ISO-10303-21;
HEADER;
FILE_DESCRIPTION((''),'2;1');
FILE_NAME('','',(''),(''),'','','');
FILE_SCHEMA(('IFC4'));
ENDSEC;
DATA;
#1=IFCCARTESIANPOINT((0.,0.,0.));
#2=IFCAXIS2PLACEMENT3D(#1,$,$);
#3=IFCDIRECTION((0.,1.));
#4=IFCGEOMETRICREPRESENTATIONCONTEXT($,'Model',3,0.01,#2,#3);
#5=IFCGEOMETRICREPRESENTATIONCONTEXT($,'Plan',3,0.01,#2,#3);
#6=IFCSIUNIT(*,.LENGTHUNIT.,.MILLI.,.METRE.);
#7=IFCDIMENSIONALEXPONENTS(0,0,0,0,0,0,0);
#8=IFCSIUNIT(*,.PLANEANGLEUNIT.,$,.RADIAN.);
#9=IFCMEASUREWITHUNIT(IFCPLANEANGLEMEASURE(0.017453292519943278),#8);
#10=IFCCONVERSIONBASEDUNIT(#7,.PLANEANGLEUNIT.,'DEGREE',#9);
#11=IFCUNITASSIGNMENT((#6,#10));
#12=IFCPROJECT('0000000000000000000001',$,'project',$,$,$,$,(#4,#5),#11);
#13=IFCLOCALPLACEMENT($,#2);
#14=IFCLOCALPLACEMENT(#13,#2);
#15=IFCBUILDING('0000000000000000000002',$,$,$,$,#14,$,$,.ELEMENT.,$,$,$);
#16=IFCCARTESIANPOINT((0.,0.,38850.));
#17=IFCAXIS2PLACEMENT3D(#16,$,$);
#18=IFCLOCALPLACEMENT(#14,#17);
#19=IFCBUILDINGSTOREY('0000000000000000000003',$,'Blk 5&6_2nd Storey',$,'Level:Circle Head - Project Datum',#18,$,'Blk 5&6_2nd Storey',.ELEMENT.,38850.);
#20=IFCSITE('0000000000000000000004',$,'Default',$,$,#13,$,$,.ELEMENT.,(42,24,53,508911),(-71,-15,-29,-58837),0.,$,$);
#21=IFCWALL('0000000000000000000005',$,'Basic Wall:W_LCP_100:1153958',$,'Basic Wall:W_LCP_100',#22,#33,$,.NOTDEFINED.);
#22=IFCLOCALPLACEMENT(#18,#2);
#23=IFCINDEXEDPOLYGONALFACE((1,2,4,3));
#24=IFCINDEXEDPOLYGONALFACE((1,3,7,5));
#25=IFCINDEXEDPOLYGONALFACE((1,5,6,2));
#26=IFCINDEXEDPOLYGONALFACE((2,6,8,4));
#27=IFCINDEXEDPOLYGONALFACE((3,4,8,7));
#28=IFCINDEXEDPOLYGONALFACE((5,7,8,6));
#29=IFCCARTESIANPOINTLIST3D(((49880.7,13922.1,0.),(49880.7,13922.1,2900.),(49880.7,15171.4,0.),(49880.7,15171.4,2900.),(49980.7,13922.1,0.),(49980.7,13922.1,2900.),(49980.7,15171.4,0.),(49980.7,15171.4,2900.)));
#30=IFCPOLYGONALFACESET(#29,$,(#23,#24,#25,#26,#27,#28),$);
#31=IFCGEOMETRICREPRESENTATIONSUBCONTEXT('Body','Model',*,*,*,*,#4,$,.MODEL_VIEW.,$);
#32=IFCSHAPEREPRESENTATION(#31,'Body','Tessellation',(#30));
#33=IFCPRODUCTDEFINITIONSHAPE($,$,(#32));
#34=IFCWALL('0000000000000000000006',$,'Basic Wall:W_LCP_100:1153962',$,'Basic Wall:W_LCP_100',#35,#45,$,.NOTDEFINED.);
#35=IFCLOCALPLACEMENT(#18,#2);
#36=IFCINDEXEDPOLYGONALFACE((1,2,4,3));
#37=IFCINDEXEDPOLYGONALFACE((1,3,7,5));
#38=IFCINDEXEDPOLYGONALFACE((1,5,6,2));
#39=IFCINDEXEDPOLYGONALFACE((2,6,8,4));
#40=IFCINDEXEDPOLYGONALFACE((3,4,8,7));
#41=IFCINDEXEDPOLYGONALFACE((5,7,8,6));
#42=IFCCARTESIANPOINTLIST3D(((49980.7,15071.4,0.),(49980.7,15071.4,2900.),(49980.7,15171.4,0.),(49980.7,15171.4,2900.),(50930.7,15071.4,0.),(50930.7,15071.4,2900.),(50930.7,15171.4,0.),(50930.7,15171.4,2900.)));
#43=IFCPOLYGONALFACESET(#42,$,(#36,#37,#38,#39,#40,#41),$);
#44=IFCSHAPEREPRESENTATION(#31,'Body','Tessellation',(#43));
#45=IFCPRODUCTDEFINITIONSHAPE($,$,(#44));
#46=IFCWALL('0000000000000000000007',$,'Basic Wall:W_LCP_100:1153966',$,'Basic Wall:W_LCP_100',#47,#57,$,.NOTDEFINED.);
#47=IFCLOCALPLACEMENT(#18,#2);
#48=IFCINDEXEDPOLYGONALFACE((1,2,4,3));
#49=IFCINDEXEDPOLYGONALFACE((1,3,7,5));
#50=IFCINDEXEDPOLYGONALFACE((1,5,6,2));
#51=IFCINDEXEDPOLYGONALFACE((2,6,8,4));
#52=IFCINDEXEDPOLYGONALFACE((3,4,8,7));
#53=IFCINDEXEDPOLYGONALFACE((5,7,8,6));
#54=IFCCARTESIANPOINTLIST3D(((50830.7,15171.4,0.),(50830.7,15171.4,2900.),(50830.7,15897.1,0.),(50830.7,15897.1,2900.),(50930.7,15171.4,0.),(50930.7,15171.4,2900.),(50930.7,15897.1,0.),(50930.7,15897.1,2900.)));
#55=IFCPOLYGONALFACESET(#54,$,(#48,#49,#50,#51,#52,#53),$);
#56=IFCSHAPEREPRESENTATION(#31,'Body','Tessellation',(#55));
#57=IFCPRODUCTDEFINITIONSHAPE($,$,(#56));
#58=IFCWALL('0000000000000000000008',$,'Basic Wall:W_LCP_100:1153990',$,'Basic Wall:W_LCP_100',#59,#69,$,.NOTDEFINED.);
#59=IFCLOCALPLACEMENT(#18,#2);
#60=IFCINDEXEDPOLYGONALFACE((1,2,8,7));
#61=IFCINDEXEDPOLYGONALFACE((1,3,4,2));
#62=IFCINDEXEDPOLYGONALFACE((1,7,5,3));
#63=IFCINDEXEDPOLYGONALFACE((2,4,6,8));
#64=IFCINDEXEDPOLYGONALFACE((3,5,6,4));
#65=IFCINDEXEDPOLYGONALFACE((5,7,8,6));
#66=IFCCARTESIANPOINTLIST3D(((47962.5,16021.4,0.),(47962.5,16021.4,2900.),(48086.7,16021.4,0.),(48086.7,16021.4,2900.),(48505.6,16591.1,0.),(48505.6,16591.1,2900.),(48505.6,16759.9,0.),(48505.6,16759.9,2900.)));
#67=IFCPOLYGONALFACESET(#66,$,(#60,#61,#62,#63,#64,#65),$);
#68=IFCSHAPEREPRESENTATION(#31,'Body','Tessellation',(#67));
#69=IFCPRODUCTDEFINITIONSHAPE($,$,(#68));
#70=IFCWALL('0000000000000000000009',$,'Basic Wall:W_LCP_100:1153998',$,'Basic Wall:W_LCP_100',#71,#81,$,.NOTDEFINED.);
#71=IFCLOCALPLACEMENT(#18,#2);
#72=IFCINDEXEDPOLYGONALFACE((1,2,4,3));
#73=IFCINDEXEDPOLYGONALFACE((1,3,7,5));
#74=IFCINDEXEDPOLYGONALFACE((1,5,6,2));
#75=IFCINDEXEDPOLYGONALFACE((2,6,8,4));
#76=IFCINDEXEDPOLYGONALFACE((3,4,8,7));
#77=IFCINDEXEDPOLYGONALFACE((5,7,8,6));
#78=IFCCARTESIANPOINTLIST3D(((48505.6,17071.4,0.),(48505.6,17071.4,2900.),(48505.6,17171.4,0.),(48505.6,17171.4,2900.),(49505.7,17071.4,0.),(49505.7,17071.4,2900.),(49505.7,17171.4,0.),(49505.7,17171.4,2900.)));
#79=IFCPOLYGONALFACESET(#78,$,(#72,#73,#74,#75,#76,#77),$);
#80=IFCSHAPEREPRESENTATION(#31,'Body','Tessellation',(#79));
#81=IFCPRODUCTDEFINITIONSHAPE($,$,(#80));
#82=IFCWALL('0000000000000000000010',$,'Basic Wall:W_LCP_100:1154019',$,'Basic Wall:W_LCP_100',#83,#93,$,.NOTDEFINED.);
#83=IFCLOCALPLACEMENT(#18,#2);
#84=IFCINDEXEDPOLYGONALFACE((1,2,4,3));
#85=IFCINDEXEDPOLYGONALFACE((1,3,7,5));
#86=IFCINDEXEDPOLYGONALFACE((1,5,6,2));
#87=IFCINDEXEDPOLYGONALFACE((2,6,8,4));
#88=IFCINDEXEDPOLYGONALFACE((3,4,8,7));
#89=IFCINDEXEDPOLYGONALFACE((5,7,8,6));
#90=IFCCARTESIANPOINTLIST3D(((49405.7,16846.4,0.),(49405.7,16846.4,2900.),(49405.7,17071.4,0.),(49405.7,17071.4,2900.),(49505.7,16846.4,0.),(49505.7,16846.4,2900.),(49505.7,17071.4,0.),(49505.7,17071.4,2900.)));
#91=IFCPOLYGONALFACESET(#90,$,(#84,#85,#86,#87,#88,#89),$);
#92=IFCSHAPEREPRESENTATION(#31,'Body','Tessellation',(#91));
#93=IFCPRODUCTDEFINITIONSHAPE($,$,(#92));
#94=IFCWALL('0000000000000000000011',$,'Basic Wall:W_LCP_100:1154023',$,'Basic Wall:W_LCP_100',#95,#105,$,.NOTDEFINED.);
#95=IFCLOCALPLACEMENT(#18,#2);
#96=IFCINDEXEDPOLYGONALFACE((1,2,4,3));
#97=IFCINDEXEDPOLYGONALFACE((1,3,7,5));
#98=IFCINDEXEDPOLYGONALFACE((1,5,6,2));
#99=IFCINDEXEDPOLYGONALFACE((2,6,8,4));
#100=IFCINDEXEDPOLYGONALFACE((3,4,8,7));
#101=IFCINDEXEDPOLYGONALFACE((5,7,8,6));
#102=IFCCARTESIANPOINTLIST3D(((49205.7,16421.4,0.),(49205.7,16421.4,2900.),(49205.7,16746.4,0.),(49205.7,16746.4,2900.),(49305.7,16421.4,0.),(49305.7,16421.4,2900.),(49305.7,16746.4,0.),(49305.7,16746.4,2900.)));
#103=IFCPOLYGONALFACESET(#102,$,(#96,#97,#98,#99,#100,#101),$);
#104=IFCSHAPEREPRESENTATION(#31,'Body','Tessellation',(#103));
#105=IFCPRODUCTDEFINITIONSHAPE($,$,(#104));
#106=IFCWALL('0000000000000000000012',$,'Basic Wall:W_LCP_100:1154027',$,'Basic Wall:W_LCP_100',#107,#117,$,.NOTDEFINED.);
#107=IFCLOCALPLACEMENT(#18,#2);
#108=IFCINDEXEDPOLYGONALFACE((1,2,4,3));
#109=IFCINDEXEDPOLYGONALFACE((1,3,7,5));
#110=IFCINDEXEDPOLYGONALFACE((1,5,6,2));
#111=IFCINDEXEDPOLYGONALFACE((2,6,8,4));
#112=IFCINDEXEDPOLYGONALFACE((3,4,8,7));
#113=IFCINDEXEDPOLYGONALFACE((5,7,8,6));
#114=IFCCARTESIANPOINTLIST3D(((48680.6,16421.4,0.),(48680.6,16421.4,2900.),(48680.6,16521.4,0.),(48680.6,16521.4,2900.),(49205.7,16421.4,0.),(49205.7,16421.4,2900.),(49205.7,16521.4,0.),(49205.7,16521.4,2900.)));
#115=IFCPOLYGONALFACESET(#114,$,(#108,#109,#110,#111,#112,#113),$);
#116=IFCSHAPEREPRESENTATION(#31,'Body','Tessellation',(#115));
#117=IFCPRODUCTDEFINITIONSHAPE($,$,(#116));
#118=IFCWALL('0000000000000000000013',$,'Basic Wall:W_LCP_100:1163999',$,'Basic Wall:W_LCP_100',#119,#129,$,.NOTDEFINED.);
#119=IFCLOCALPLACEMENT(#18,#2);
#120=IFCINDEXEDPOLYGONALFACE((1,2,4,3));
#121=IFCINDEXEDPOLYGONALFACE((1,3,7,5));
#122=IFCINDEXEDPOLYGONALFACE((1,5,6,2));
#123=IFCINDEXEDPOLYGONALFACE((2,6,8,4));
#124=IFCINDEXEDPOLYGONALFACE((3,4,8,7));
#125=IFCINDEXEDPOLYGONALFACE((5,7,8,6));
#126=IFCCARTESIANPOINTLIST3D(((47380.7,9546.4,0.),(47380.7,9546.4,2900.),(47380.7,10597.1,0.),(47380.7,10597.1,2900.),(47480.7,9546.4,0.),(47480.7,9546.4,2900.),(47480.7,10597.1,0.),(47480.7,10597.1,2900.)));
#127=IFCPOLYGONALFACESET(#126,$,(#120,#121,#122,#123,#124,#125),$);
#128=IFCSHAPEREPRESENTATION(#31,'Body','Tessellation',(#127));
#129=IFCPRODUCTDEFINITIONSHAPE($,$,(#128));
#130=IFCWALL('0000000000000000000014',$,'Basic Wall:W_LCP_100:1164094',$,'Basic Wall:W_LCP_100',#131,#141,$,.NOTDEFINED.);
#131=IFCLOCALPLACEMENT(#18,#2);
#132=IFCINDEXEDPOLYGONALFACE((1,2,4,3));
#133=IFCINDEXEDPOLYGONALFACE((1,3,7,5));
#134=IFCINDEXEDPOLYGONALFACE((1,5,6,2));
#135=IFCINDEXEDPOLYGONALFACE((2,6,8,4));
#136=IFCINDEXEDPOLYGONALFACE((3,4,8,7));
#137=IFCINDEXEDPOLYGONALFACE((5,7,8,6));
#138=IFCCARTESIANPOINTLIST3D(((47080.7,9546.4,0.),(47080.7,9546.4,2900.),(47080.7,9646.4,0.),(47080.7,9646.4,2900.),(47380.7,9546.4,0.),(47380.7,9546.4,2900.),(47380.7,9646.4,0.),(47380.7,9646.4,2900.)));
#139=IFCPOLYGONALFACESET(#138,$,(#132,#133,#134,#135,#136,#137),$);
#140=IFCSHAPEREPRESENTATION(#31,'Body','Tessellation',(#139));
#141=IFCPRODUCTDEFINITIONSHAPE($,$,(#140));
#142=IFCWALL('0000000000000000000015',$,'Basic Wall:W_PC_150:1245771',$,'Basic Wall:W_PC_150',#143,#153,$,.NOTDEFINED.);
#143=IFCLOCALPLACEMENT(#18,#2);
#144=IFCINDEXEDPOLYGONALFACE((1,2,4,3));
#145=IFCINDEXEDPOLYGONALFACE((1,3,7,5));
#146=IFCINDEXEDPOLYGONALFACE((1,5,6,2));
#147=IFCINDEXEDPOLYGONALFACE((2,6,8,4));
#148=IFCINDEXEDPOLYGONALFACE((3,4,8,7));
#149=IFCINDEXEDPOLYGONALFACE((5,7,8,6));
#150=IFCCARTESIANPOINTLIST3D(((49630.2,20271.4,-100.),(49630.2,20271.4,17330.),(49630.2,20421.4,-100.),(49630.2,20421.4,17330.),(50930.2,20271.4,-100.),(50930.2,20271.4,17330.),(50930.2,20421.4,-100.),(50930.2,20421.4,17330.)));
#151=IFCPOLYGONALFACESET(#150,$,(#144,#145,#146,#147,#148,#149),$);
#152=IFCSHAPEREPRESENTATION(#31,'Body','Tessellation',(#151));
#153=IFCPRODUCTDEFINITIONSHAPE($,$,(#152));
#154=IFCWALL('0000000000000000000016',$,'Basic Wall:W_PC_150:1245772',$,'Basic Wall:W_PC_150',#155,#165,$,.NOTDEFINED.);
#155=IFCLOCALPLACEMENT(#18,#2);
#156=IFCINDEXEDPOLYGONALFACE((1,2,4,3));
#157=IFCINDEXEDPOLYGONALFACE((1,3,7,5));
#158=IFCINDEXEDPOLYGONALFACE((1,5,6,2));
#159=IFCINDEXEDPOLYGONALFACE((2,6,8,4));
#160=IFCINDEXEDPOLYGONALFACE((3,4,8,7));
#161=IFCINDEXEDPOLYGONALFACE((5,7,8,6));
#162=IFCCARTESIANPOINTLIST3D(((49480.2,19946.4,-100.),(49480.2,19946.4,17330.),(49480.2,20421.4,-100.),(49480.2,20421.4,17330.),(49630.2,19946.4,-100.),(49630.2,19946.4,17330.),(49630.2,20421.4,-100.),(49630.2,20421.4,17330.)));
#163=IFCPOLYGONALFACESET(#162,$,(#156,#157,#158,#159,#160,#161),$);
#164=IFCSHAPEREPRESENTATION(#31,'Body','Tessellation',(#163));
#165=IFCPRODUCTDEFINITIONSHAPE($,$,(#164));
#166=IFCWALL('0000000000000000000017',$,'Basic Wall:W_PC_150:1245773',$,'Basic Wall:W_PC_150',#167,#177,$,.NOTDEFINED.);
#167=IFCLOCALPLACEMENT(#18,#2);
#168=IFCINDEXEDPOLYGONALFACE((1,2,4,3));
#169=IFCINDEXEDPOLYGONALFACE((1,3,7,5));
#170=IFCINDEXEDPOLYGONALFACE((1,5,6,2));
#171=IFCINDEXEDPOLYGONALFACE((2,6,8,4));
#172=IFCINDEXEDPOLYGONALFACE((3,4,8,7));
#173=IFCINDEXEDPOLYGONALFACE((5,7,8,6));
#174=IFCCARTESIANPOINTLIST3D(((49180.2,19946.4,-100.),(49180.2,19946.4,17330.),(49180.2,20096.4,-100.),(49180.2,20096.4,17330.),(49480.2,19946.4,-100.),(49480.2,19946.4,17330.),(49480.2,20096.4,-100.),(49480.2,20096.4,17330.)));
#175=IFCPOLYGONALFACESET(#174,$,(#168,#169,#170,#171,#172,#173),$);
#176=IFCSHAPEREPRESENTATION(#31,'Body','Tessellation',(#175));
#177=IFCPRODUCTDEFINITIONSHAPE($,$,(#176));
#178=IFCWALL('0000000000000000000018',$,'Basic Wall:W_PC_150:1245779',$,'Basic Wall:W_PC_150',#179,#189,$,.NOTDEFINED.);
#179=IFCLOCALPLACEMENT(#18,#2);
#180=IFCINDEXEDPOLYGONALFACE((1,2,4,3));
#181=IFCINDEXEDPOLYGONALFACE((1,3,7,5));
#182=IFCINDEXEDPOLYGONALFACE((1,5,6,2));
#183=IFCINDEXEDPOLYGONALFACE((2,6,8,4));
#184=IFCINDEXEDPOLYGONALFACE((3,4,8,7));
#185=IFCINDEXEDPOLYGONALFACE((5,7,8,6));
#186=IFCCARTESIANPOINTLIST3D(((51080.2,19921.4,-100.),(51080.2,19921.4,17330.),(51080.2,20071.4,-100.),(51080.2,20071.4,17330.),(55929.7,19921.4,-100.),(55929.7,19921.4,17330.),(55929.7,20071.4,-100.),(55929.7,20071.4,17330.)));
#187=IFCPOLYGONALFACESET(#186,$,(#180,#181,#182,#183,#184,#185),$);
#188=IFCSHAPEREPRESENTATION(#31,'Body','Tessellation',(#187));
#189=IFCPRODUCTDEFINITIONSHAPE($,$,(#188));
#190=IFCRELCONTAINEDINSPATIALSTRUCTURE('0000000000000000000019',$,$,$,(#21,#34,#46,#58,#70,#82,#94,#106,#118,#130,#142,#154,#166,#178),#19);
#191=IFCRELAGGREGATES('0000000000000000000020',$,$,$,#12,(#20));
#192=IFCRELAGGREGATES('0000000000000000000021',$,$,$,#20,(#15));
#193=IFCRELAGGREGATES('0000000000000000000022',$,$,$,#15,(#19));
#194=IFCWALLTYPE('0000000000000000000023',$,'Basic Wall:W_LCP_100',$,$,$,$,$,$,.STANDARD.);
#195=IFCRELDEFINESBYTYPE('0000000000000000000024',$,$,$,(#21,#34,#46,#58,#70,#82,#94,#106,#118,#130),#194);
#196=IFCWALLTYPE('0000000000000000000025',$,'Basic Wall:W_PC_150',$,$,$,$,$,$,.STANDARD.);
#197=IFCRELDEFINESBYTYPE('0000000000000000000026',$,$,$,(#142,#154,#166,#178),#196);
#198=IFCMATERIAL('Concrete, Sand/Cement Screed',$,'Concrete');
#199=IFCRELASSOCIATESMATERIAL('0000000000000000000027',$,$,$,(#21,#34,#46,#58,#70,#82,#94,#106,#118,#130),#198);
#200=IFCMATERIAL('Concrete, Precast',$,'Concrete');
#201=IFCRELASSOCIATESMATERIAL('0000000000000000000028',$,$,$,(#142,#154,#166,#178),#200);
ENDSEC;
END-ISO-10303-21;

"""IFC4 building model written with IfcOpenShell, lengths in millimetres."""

from ifc_helpers import new_model, entity, si_unit, converted_unit, direction, frame, origin, place, context, subcontext, project, spatial, indexed_curve, outline, extrude, material, type_object, element, save


model = new_model("IFC4")

# Units and contexts
model_context = context("Model", 3, precision=0.01, world=origin(), true_north=direction((0.0, 1.0)))
plan_context = context("Plan", 3, precision=0.01, world=origin(), true_north=direction((0.0, 1.0)))
body_context = subcontext(model_context, "Body", "Model", "MODEL_VIEW")
ifc_project = project(units=[si_unit("LENGTHUNIT", "METRE", prefix="MILLI"), converted_unit("PLANEANGLEUNIT", "DEGREE", entity("IfcPlaneAngleMeasure", 0.017453292519943278), si_unit("PLANEANGLEUNIT", "RADIAN"), dimensions=[0, 0, 0, 0, 0, 0, 0])], contexts=[model_context, plan_context])

# Site, building, storey
site_placement = place(None, origin())
site = spatial("IfcSite", under=ifc_project, at=site_placement, Name="Default", CompositionType="ELEMENT", RefLatitude=(42, 24, 53, 508911), RefLongitude=(-71, -15, -29, -58837), RefElevation=0.0)
building_placement = place(site_placement, origin())
building = spatial("IfcBuilding", under=site, at=building_placement, CompositionType="ELEMENT")
storey_placement = place(building_placement, frame((0.0, 0.0, 38850.0)))
storey = spatial("IfcBuildingStorey", under=building, at=storey_placement, Name="Blk 5&6_2nd Storey", ObjectType="Level:Circle Head - Project Datum", LongName="Blk 5&6_2nd Storey", CompositionType="ELEMENT", Elevation=38850.0)

# Walls
ifc_material_1 = material(Name="Concrete, Sand/Cement Screed", Category="Concrete")
wall_type_1 = type_object("IfcWallType", Name="Basic Wall:W_LCP_100", PredefinedType="STANDARD")
wall_1_placement = place(storey_placement, frame((49930.7, 15171.4, 0.0), z_axis=(0.0, 0.0, 1.0), x_axis=(0.0, -1.0, 0.0)))
element("IfcWall", 1, at=wall_1_placement, inside=storey, type_object=wall_type_1, material=ifc_material_1, Name="Basic Wall:W_LCP_100:1153958", ObjectType="Basic Wall:W_LCP_100", PredefinedType="NOTDEFINED", context=body_context, shape_type="SweptSolid", body=[
    extrude(outline(indexed_curve([(1249.3, 50.0), (0.0, 50.0), (0.0, -50.0), (1249.3, -50.0), (1249.3, 50.0)], self_intersect=False)), origin(), (0.0, 0.0, 1.0), 2900.0),
])
wall_2_placement = place(storey_placement, frame((50930.7, 15121.4, 0.0), z_axis=(0.0, 0.0, 1.0), x_axis=(-1.0, 0.0, 0.0)))
element("IfcWall", 2, at=wall_2_placement, inside=storey, type_object=wall_type_1, material=ifc_material_1, Name="Basic Wall:W_LCP_100:1153962", ObjectType="Basic Wall:W_LCP_100", PredefinedType="NOTDEFINED", context=body_context, shape_type="SweptSolid", body=[
    extrude(outline(indexed_curve([(950.0, 50.0), (0.0, 50.0), (0.0, -50.0), (950.0, -50.0), (950.0, 50.0)], self_intersect=False)), origin(), (0.0, 0.0, 1.0), 2900.0),
])
wall_3_placement = place(storey_placement, frame((50880.7, 15171.4, 0.0), z_axis=(0.0, 0.0, 1.0), x_axis=(0.0, 1.0, 0.0)))
element("IfcWall", 3, at=wall_3_placement, inside=storey, type_object=wall_type_1, material=ifc_material_1, Name="Basic Wall:W_LCP_100:1153966", ObjectType="Basic Wall:W_LCP_100", PredefinedType="NOTDEFINED", context=body_context, shape_type="SweptSolid", body=[
    extrude(outline(indexed_curve([(725.7, 50.0), (0.0, 50.0), (0.0, -50.0), (725.7, -50.0), (725.7, 50.0)], self_intersect=False)), origin(), (0.0, 0.0, 1.0), 2900.0),
])
wall_4_placement = place(storey_placement, frame((48002.8, 15991.8, 0.0), z_axis=(0.0, 0.0, 1.0), x_axis=(0.592446, 0.80561, 0.0)))
element("IfcWall", 4, at=wall_4_placement, inside=storey, type_object=wall_type_1, material=ifc_material_1, Name="Basic Wall:W_LCP_100:1153990", ObjectType="Basic Wall:W_LCP_100", PredefinedType="NOTDEFINED", context=body_context, shape_type="SweptSolid", body=[
    extrude(outline(indexed_curve([(780.7, -50.0), (916.7, 50.0), (0.0, 50.0), (73.5, -50.0), (780.7, -50.0)], self_intersect=False)), origin(), (0.0, 0.0, 1.0), 2900.0),
])
wall_5_placement = place(storey_placement, frame((48505.6, 17121.4, 0.0)))
element("IfcWall", 5, at=wall_5_placement, inside=storey, type_object=wall_type_1, material=ifc_material_1, Name="Basic Wall:W_LCP_100:1153998", ObjectType="Basic Wall:W_LCP_100", PredefinedType="NOTDEFINED", context=body_context, shape_type="SweptSolid", body=[
    extrude(outline(indexed_curve([(1000.0, 50.0), (0.0, 50.0), (0.0, -50.0), (1000.0, -50.0), (1000.0, 50.0)], self_intersect=False)), origin(), (0.0, 0.0, 1.0), 2900.0),
])
wall_6_placement = place(storey_placement, frame((49455.7, 16846.4, 0.0), z_axis=(0.0, 0.0, 1.0), x_axis=(0.0, 1.0, 0.0)))
element("IfcWall", 6, at=wall_6_placement, inside=storey, type_object=wall_type_1, material=ifc_material_1, Name="Basic Wall:W_LCP_100:1154019", ObjectType="Basic Wall:W_LCP_100", PredefinedType="NOTDEFINED", context=body_context, shape_type="SweptSolid", body=[
    extrude(outline(indexed_curve([(225.0, 50.0), (0.0, 50.0), (0.0, -50.0), (225.0, -50.0), (225.0, 50.0)], self_intersect=False)), origin(), (0.0, 0.0, 1.0), 2900.0),
])
wall_7_placement = place(storey_placement, frame((49255.7, 16421.4, 0.0), z_axis=(0.0, 0.0, 1.0), x_axis=(0.0, 1.0, 0.0)))
element("IfcWall", 7, at=wall_7_placement, inside=storey, type_object=wall_type_1, material=ifc_material_1, Name="Basic Wall:W_LCP_100:1154023", ObjectType="Basic Wall:W_LCP_100", PredefinedType="NOTDEFINED", context=body_context, shape_type="SweptSolid", body=[
    extrude(outline(indexed_curve([(325.0, 50.0), (0.0, 50.0), (0.0, -50.0), (325.0, -50.0), (325.0, 50.0)], self_intersect=False)), origin(), (0.0, 0.0, 1.0), 2900.0),
])
wall_8_placement = place(storey_placement, frame((48680.6, 16471.4, 0.0)))
element("IfcWall", 8, at=wall_8_placement, inside=storey, type_object=wall_type_1, material=ifc_material_1, Name="Basic Wall:W_LCP_100:1154027", ObjectType="Basic Wall:W_LCP_100", PredefinedType="NOTDEFINED", context=body_context, shape_type="SweptSolid", body=[
    extrude(outline(indexed_curve([(525.0, 50.0), (0.0, 50.0), (0.0, -50.0), (525.0, -50.0), (525.0, 50.0)], self_intersect=False)), origin(), (0.0, 0.0, 1.0), 2900.0),
])
wall_9_placement = place(storey_placement, frame((47430.7, 9546.4, 0.0), z_axis=(0.0, 0.0, 1.0), x_axis=(0.0, 1.0, 0.0)))
element("IfcWall", 9, at=wall_9_placement, inside=storey, type_object=wall_type_1, material=ifc_material_1, Name="Basic Wall:W_LCP_100:1163999", ObjectType="Basic Wall:W_LCP_100", PredefinedType="NOTDEFINED", context=body_context, shape_type="SweptSolid", body=[
    extrude(outline(indexed_curve([(1050.7, 50.0), (0.0, 50.0), (0.0, -50.0), (1050.7, -50.0), (1050.7, 50.0)], self_intersect=False)), origin(), (0.0, 0.0, 1.0), 2900.0),
])
wall_10_placement = place(storey_placement, frame((47380.7, 9596.4, 0.0), z_axis=(0.0, 0.0, 1.0), x_axis=(-1.0, 0.0, 0.0)))
element("IfcWall", 10, at=wall_10_placement, inside=storey, type_object=wall_type_1, material=ifc_material_1, Name="Basic Wall:W_LCP_100:1164094", ObjectType="Basic Wall:W_LCP_100", PredefinedType="NOTDEFINED", context=body_context, shape_type="SweptSolid", body=[
    extrude(outline(indexed_curve([(300.0, 50.0), (0.0, 50.0), (0.0, -50.0), (300.0, -50.0), (300.0, 50.0)], self_intersect=False)), origin(), (0.0, 0.0, 1.0), 2900.0),
])
ifc_material_2 = material(Name="Concrete, Precast", Category="Concrete")
wall_type_2 = type_object("IfcWallType", Name="Basic Wall:W_PC_150", PredefinedType="STANDARD")
wall_11_placement = place(storey_placement, frame((50930.2, 20346.4, -100.0), z_axis=(0.0, 0.0, 1.0), x_axis=(-1.0, 0.0, 0.0)))
element("IfcWall", 11, at=wall_11_placement, inside=storey, type_object=wall_type_2, material=ifc_material_2, Name="Basic Wall:W_PC_150:1245771", ObjectType="Basic Wall:W_PC_150", PredefinedType="NOTDEFINED", context=body_context, shape_type="SweptSolid", body=[
    extrude(outline(indexed_curve([(1300.0, 75.0), (0.0, 75.0), (0.0, -75.0), (1300.0, -75.0), (1300.0, 75.0)], self_intersect=False)), origin(), (0.0, 0.0, 1.0), 17430.0),
])
wall_12_placement = place(storey_placement, frame((49555.2, 20421.4, -100.0), z_axis=(0.0, 0.0, 1.0), x_axis=(0.0, -1.0, 0.0)))
element("IfcWall", 12, at=wall_12_placement, inside=storey, type_object=wall_type_2, material=ifc_material_2, Name="Basic Wall:W_PC_150:1245772", ObjectType="Basic Wall:W_PC_150", PredefinedType="NOTDEFINED", context=body_context, shape_type="SweptSolid", body=[
    extrude(outline(indexed_curve([(475.0, 75.0), (0.0, 75.0), (0.0, -75.0), (475.0, -75.0), (475.0, 75.0)], self_intersect=False)), origin(), (0.0, 0.0, 1.0), 17430.0),
])
wall_13_placement = place(storey_placement, frame((49480.2, 20021.4, -100.0), z_axis=(0.0, 0.0, 1.0), x_axis=(-1.0, 0.0, 0.0)))
element("IfcWall", 13, at=wall_13_placement, inside=storey, type_object=wall_type_2, material=ifc_material_2, Name="Basic Wall:W_PC_150:1245773", ObjectType="Basic Wall:W_PC_150", PredefinedType="NOTDEFINED", context=body_context, shape_type="SweptSolid", body=[
    extrude(outline(indexed_curve([(300.0, 75.0), (0.0, 75.0), (0.0, -75.0), (300.0, -75.0), (300.0, 75.0)], self_intersect=False)), origin(), (0.0, 0.0, 1.0), 17430.0),
])
wall_14_placement = place(storey_placement, frame((55929.7, 19996.4, -100.0), z_axis=(0.0, 0.0, 1.0), x_axis=(-1.0, 0.0, 0.0)))
element("IfcWall", 14, at=wall_14_placement, inside=storey, type_object=wall_type_2, material=ifc_material_2, Name="Basic Wall:W_PC_150:1245779", ObjectType="Basic Wall:W_PC_150", PredefinedType="NOTDEFINED", context=body_context, shape_type="SweptSolid", body=[
    extrude(outline(indexed_curve([(4849.5, 75.0), (0.0, 75.0), (0.0, -75.0), (4849.5, -75.0), (4849.5, 75.0)], self_intersect=False)), origin(), (0.0, 0.0, 1.0), 17430.0),
])

save(model, "model.ifc")
